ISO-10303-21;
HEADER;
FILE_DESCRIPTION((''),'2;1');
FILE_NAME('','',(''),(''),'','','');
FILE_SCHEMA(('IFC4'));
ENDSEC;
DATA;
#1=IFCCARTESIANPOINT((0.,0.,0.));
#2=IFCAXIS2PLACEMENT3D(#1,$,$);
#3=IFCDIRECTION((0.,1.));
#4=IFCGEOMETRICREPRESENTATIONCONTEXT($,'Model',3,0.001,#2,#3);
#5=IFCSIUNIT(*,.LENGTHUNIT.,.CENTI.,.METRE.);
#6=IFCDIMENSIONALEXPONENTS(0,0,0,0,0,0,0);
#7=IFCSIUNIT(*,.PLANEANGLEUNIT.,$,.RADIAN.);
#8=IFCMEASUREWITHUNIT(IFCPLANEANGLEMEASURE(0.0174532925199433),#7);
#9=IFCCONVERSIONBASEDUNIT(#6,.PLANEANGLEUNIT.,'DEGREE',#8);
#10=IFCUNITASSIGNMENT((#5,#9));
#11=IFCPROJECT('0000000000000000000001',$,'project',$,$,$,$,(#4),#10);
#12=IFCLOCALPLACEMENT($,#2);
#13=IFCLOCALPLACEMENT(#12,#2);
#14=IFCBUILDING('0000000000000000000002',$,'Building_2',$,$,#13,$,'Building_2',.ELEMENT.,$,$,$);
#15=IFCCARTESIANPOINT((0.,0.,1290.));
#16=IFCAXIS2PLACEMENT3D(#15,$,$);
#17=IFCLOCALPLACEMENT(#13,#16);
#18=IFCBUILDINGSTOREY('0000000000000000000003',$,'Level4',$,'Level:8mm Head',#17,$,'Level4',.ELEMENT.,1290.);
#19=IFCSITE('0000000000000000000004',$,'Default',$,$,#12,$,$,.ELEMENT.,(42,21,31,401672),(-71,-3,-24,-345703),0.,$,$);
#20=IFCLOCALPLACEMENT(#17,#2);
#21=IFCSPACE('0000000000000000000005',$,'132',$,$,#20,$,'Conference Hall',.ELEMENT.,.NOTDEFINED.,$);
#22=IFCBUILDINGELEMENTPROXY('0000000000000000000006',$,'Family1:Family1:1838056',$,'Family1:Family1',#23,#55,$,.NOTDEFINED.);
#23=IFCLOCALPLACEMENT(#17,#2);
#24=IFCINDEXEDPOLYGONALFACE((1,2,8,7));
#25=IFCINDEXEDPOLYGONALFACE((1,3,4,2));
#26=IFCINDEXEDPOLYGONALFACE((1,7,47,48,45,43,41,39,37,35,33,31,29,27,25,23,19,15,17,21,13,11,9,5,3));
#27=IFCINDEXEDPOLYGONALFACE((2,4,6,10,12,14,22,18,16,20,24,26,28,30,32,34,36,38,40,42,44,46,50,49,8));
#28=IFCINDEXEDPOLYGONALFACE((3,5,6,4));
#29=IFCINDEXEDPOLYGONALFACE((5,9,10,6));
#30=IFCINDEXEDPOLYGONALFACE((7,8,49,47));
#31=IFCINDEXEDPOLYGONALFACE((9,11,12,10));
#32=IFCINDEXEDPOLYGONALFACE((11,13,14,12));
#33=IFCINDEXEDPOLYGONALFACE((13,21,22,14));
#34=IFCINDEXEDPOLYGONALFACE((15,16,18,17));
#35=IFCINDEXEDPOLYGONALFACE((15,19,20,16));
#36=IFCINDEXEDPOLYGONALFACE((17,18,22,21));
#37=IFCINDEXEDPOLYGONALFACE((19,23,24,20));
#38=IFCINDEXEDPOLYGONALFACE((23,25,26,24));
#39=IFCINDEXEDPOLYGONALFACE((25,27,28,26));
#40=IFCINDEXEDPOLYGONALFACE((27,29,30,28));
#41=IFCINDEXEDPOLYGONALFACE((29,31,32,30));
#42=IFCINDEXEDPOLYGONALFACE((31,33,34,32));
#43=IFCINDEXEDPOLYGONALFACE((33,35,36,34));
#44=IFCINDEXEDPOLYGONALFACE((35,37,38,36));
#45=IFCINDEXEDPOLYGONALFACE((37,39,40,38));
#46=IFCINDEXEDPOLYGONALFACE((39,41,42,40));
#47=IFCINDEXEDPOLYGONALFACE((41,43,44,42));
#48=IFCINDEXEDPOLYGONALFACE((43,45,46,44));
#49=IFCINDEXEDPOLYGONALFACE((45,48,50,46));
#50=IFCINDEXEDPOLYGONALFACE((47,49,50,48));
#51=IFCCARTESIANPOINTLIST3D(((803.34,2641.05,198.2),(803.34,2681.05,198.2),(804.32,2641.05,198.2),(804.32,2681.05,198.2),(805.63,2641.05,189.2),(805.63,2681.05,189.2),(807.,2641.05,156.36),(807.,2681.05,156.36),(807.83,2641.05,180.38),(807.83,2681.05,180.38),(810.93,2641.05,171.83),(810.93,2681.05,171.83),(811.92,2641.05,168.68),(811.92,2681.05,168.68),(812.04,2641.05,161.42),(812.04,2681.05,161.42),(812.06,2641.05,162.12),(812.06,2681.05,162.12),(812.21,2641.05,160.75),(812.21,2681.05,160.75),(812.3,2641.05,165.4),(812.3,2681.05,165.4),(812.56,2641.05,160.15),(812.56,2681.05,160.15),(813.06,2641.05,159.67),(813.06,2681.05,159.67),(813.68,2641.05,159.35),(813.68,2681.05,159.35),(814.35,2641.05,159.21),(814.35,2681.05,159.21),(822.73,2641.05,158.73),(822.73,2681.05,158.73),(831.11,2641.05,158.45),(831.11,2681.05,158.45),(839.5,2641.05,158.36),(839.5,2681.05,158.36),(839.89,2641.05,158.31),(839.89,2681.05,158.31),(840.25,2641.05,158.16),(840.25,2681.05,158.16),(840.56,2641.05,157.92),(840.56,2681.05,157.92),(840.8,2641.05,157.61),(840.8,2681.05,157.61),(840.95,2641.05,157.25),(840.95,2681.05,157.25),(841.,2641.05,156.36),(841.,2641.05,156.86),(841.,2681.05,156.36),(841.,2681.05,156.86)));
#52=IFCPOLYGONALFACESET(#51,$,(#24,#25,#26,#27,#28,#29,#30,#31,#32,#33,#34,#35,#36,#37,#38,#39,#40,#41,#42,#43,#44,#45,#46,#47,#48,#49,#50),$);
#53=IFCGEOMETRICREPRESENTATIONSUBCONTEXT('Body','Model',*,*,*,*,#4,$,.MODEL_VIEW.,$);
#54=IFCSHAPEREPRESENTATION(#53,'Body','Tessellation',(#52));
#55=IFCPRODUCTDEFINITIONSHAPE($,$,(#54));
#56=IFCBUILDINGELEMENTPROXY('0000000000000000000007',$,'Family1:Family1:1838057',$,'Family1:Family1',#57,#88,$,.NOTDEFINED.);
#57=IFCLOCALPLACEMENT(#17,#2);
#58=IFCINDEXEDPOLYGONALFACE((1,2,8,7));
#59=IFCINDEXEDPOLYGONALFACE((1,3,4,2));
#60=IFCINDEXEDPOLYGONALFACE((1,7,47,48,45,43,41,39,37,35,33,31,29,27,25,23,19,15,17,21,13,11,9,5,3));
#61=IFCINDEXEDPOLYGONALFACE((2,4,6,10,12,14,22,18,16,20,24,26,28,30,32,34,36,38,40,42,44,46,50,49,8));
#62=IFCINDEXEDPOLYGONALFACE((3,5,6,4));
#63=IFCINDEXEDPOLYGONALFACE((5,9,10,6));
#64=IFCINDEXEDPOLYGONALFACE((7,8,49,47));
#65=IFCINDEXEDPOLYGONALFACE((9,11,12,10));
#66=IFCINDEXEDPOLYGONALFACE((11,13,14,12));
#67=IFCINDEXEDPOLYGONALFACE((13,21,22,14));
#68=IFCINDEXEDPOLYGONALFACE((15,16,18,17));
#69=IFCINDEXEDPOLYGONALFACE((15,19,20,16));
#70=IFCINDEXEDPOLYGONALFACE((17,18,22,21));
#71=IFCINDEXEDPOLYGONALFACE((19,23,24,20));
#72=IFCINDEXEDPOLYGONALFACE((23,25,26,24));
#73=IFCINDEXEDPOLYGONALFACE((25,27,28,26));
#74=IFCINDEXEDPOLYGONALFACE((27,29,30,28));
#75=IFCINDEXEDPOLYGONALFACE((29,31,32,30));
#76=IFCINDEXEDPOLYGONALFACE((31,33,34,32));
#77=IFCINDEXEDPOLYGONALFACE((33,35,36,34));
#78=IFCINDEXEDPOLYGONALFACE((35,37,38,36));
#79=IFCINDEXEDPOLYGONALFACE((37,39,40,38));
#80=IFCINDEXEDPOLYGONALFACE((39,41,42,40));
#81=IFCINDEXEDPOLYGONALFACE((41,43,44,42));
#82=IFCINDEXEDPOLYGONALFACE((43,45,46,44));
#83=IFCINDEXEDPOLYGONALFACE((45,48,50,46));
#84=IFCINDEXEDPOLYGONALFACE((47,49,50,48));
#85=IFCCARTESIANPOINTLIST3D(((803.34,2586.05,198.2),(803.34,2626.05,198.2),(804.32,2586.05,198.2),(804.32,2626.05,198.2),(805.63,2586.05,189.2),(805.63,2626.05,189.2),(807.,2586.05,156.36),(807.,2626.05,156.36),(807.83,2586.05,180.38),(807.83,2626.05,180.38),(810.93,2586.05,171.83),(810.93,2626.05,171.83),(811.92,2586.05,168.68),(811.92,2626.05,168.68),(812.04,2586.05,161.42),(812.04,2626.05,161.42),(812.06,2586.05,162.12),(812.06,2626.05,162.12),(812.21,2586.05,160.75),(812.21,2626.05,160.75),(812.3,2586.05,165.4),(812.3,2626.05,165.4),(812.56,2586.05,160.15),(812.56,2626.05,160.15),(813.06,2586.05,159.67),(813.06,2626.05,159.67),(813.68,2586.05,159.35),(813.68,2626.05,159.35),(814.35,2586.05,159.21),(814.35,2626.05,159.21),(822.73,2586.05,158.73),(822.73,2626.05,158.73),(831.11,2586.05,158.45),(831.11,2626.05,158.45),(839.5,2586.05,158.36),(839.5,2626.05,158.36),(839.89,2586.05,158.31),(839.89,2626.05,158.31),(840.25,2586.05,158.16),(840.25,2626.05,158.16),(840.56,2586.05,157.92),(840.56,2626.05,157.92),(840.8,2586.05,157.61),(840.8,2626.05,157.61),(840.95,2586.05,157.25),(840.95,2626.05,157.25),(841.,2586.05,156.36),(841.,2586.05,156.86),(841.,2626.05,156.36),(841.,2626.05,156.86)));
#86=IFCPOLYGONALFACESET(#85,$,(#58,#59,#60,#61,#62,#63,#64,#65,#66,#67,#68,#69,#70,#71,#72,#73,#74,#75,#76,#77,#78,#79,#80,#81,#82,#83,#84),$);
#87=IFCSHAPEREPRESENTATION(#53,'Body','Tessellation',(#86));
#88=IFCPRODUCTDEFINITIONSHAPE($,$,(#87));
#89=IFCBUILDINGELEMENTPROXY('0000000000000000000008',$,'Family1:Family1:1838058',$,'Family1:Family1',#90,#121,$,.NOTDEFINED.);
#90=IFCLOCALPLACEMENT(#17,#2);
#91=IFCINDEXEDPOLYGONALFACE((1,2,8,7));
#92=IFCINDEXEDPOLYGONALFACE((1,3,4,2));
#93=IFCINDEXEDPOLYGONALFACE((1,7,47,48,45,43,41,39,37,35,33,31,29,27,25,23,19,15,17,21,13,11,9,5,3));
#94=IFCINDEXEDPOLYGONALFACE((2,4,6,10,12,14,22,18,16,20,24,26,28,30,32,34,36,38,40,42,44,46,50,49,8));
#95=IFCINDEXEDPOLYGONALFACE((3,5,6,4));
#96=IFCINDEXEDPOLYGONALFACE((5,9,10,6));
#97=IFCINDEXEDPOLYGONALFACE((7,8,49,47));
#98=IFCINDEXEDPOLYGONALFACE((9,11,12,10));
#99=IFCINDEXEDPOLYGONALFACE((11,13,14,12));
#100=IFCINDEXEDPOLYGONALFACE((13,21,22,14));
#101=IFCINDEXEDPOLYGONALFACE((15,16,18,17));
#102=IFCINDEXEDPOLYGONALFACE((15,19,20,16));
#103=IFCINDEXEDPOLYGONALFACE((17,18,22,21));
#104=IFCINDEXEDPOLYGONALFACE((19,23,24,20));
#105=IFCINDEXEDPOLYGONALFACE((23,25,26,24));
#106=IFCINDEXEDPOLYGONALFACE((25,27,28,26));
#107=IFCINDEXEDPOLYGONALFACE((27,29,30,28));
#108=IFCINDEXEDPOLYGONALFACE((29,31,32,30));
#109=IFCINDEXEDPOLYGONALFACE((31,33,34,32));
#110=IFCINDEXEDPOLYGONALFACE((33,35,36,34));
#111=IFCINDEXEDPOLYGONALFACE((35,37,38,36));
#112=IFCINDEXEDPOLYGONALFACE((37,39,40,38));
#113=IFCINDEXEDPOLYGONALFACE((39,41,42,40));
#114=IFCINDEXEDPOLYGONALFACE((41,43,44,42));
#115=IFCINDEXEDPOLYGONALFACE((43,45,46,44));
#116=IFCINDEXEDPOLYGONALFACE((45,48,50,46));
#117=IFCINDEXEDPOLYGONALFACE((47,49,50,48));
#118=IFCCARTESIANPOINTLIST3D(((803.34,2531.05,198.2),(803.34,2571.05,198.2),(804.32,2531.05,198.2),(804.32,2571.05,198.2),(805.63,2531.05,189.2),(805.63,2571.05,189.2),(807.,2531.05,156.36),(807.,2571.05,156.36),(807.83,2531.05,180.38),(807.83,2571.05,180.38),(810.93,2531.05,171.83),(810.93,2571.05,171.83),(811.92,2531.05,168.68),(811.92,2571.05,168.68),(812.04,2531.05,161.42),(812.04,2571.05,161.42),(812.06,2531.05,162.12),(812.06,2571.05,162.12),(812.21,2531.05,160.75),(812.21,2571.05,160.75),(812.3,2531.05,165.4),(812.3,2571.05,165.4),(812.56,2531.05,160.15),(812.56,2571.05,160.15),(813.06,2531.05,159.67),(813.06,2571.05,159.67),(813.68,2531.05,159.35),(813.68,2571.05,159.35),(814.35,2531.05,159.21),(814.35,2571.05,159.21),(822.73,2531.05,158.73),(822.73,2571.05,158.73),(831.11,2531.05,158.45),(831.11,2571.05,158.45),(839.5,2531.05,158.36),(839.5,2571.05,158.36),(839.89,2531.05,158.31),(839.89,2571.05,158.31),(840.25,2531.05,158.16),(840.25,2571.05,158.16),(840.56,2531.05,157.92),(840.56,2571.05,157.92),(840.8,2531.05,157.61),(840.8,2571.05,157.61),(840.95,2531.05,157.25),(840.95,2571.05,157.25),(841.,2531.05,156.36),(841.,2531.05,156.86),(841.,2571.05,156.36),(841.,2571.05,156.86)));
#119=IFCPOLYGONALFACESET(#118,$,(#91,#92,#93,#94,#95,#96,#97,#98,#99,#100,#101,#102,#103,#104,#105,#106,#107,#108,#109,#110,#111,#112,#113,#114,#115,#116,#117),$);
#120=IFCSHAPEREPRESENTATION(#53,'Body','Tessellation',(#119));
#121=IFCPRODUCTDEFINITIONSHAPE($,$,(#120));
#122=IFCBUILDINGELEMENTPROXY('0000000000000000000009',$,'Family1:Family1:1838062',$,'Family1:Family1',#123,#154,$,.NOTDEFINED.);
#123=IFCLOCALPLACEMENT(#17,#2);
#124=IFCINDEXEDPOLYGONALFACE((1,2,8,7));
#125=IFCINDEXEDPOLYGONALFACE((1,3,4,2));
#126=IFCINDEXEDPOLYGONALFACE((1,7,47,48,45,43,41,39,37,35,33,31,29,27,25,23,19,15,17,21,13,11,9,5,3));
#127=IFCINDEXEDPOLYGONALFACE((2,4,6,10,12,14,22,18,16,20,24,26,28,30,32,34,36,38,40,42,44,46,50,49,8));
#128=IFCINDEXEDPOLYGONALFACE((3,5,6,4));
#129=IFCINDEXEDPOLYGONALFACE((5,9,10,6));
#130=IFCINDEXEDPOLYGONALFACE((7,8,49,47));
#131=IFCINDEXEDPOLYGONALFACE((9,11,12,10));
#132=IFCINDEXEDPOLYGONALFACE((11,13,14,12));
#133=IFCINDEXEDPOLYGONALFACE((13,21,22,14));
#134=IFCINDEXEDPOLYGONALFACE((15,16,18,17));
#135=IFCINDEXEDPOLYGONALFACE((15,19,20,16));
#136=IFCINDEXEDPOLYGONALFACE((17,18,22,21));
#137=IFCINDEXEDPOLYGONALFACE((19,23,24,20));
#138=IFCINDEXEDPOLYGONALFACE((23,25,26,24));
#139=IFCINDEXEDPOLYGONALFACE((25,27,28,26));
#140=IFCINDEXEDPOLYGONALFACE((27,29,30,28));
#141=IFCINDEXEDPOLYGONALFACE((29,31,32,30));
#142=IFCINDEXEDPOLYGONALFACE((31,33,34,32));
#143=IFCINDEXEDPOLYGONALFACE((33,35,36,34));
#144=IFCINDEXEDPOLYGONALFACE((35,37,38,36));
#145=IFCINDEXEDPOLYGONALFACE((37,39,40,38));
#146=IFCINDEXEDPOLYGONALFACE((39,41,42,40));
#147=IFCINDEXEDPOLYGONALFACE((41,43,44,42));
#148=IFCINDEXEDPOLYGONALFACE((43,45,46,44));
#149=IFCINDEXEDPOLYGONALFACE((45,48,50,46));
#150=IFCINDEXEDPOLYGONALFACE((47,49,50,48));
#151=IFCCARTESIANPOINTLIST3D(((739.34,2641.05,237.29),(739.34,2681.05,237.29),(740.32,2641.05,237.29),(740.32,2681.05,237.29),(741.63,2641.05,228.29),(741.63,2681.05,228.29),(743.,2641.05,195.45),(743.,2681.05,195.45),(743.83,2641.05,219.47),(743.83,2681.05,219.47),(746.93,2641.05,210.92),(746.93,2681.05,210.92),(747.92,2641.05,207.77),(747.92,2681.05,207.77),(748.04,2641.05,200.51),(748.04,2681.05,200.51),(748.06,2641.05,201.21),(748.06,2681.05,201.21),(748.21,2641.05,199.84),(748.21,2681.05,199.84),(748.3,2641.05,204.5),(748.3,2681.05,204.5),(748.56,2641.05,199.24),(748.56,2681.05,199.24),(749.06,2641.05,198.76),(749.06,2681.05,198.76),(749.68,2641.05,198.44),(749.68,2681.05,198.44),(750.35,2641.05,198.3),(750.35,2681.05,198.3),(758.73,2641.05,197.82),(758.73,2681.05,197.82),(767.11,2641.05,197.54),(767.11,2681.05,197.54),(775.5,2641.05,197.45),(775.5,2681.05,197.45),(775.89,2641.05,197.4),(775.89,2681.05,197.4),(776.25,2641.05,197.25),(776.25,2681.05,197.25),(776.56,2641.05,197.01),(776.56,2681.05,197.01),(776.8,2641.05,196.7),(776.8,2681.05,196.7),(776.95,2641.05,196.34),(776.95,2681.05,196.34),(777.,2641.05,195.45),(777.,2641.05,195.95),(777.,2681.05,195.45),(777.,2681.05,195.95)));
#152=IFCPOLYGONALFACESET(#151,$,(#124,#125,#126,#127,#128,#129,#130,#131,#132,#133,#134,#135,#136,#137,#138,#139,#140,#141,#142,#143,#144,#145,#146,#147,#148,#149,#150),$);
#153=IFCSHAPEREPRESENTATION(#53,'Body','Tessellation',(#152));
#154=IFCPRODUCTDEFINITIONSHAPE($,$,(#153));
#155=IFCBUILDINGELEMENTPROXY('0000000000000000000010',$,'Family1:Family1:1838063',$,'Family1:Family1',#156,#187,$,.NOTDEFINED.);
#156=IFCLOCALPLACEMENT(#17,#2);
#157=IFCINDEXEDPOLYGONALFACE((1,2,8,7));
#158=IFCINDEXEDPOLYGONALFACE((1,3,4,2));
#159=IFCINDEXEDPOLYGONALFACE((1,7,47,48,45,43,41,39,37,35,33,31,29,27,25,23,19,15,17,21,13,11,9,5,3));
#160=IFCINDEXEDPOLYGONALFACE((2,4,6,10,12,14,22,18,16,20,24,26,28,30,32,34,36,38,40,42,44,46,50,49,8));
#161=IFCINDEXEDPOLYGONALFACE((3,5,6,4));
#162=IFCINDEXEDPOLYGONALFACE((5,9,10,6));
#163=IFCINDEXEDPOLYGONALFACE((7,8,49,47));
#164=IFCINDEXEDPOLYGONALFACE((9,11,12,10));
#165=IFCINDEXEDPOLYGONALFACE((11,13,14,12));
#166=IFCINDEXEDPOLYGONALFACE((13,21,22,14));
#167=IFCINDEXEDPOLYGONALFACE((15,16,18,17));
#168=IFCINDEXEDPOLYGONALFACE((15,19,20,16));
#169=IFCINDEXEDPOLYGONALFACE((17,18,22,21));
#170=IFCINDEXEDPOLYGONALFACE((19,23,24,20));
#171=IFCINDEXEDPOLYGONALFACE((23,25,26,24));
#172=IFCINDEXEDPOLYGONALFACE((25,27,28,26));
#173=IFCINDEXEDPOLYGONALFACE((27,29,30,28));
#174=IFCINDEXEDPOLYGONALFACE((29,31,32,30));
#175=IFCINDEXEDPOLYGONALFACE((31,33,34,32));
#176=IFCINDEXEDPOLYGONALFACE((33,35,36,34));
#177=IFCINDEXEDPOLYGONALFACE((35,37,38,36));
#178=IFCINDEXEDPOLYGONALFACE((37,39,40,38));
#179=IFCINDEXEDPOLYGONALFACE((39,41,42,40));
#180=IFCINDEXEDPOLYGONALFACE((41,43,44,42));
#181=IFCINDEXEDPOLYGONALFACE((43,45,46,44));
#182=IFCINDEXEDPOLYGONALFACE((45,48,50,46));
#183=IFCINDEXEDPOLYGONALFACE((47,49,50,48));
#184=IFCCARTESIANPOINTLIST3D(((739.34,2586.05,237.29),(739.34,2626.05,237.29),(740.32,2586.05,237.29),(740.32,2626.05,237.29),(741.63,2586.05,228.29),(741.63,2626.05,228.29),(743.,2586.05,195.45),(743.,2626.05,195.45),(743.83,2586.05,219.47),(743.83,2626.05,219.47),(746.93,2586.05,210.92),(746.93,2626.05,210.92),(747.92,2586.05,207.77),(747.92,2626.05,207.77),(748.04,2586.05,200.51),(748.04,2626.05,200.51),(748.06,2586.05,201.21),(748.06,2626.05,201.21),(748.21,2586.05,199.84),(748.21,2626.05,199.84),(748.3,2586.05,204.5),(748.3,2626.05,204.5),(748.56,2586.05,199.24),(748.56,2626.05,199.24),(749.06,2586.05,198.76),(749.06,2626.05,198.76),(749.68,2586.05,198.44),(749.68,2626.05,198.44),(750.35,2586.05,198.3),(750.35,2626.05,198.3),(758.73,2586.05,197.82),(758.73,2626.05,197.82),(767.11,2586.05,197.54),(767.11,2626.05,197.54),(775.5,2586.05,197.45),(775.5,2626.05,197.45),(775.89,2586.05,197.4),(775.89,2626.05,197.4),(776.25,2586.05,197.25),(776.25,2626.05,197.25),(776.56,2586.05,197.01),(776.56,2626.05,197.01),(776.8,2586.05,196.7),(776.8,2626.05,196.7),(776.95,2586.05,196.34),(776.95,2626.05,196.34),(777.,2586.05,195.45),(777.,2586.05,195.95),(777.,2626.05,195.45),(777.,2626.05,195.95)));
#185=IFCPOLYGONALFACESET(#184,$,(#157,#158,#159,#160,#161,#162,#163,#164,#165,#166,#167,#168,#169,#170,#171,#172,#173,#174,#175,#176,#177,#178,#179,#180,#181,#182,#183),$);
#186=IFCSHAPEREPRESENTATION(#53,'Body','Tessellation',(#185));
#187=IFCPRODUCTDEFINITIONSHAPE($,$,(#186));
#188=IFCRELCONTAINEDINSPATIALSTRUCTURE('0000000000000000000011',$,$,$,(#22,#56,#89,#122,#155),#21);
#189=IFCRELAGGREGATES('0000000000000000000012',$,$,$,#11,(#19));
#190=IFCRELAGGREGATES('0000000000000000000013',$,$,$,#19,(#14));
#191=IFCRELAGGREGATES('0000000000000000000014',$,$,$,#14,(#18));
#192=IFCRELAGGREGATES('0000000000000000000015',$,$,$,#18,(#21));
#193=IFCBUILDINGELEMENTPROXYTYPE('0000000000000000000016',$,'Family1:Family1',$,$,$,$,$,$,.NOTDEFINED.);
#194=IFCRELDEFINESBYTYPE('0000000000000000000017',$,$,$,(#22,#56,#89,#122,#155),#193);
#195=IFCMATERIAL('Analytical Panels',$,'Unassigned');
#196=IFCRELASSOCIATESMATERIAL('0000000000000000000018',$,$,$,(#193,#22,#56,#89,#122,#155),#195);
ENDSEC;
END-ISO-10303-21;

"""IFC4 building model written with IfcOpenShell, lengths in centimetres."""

from ifc_helpers import new_model, entity, si_unit, converted_unit, direction, frame, origin, place, context, subcontext, project, spatial, line, arc, indexed_curve, outline, extrude, source, transform, mapped, material, type_object, type_shapes, element, save


model = new_model("IFC4")

# Units and contexts
model_context = context("Model", 3, precision=0.001, world=origin(), true_north=direction((0.0, 1.0)))
body_context = subcontext(model_context, "Body", "Model", "MODEL_VIEW")
ifc_project = project(units=[si_unit("LENGTHUNIT", "METRE", prefix="CENTI"), converted_unit("PLANEANGLEUNIT", "DEGREE", entity("IfcPlaneAngleMeasure", 0.0174532925199433), si_unit("PLANEANGLEUNIT", "RADIAN"), dimensions=[0, 0, 0, 0, 0, 0, 0])], contexts=[model_context])

# Site, building, storey
site_placement = place(None, origin())
site = spatial("IfcSite", under=ifc_project, at=site_placement, Name="Default", CompositionType="ELEMENT", RefLatitude=(42, 21, 31, 401672), RefLongitude=(-71, -3, -24, -345703), RefElevation=0.0)
building_placement = place(site_placement, origin())
building = spatial("IfcBuilding", under=site, at=building_placement, Name="Building_2", LongName="Building_2", CompositionType="ELEMENT")
storey_placement = place(building_placement, frame((0.0, 0.0, 1290.0)))
storey = spatial("IfcBuildingStorey", under=building, at=storey_placement, Name="Level4", ObjectType="Level:8mm Head", LongName="Level4", CompositionType="ELEMENT", Elevation=1290.0)

# Shared definitions
space_1_placement = place(storey_placement, origin())
space_1 = spatial("IfcSpace", under=storey, at=space_1_placement, Name="132", LongName="Conference Hall", CompositionType="ELEMENT", PredefinedType="NOTDEFINED")

# Building element proxies
ifc_material_1 = material(Name="Analytical Panels", Category="Unassigned")
building_element_proxy_type_1 = type_object("IfcBuildingElementProxyType", Name="Family1:Family1", PredefinedType="NOTDEFINED", material=ifc_material_1)
shared_shape_1 = source(origin(), body_context, "Body", "SweptSolid", [
    extrude(outline(indexed_curve([(-11.13, -13.3), (30.87, -13.3), (30.78, -12.32), (17.19, -11.21), (3.93, -8.04), (-0.94, -7.2), (-5.84, -7.76), (-7.84, -7.43), (-8.94, -5.73), (-10.68, 6.74), (-11.98, 19.25), (-12.51, 20.27), (-13.6, 20.61), (-14.09, 20.57)], segments=[line(1, 2, 3), arc(3, 4, 5), arc(5, 6, 7), arc(7, 8, 9), arc(9, 10, 11), arc(11, 12, 13), line(13, 14, 1)], self_intersect=False)), frame((-20.0, 6.72, 12.25), z_axis=(1.0, 0.0, 0.0), x_axis=(0.0, 0.087156, 0.996195)), (0.0, 0.0, 1.0), 40.0),
])
type_shapes(building_element_proxy_type_1, [shared_shape_1])
for number, where, z_axis, x_axis, name in (
    (1, (826.0, 2661.05, 156.36), (0.0, 0.0, 1.0), (0.0, 1.0, 0.0), "Family1:Family1:1838056"),
    (2, (826.0, 2606.05, 156.36), (0.0, 0.0, 1.0), (0.0, 1.0, 0.0), "Family1:Family1:1838057"),
    (3, (826.0, 2551.05, 156.36), (0.0, 0.0, 1.0), (0.0, 1.0, 0.0), "Family1:Family1:1838058"),
    (4, (762.0, 2661.05, 195.45), (0.0, 0.0, 1.0), (0.0, 1.0, 0.0), "Family1:Family1:1838062"),
    (5, (762.0, 2606.05, 195.45), (0.0, 0.0, 1.0), (0.0, 1.0, 0.0), "Family1:Family1:1838063"),
):
    element("IfcBuildingElementProxy", number, at=place(space_1_placement, frame(where, z_axis=z_axis, x_axis=x_axis)), inside=space_1, type_object=building_element_proxy_type_1, material=ifc_material_1, Name=name, ObjectType="Family1:Family1", PredefinedType="NOTDEFINED", context=body_context, shape_type="MappedRepresentation", body=[
        mapped(shared_shape_1, transform((0.0, 0.0, 0.0), scale=1.0)),
    ])

save(model, "model.ifc")
